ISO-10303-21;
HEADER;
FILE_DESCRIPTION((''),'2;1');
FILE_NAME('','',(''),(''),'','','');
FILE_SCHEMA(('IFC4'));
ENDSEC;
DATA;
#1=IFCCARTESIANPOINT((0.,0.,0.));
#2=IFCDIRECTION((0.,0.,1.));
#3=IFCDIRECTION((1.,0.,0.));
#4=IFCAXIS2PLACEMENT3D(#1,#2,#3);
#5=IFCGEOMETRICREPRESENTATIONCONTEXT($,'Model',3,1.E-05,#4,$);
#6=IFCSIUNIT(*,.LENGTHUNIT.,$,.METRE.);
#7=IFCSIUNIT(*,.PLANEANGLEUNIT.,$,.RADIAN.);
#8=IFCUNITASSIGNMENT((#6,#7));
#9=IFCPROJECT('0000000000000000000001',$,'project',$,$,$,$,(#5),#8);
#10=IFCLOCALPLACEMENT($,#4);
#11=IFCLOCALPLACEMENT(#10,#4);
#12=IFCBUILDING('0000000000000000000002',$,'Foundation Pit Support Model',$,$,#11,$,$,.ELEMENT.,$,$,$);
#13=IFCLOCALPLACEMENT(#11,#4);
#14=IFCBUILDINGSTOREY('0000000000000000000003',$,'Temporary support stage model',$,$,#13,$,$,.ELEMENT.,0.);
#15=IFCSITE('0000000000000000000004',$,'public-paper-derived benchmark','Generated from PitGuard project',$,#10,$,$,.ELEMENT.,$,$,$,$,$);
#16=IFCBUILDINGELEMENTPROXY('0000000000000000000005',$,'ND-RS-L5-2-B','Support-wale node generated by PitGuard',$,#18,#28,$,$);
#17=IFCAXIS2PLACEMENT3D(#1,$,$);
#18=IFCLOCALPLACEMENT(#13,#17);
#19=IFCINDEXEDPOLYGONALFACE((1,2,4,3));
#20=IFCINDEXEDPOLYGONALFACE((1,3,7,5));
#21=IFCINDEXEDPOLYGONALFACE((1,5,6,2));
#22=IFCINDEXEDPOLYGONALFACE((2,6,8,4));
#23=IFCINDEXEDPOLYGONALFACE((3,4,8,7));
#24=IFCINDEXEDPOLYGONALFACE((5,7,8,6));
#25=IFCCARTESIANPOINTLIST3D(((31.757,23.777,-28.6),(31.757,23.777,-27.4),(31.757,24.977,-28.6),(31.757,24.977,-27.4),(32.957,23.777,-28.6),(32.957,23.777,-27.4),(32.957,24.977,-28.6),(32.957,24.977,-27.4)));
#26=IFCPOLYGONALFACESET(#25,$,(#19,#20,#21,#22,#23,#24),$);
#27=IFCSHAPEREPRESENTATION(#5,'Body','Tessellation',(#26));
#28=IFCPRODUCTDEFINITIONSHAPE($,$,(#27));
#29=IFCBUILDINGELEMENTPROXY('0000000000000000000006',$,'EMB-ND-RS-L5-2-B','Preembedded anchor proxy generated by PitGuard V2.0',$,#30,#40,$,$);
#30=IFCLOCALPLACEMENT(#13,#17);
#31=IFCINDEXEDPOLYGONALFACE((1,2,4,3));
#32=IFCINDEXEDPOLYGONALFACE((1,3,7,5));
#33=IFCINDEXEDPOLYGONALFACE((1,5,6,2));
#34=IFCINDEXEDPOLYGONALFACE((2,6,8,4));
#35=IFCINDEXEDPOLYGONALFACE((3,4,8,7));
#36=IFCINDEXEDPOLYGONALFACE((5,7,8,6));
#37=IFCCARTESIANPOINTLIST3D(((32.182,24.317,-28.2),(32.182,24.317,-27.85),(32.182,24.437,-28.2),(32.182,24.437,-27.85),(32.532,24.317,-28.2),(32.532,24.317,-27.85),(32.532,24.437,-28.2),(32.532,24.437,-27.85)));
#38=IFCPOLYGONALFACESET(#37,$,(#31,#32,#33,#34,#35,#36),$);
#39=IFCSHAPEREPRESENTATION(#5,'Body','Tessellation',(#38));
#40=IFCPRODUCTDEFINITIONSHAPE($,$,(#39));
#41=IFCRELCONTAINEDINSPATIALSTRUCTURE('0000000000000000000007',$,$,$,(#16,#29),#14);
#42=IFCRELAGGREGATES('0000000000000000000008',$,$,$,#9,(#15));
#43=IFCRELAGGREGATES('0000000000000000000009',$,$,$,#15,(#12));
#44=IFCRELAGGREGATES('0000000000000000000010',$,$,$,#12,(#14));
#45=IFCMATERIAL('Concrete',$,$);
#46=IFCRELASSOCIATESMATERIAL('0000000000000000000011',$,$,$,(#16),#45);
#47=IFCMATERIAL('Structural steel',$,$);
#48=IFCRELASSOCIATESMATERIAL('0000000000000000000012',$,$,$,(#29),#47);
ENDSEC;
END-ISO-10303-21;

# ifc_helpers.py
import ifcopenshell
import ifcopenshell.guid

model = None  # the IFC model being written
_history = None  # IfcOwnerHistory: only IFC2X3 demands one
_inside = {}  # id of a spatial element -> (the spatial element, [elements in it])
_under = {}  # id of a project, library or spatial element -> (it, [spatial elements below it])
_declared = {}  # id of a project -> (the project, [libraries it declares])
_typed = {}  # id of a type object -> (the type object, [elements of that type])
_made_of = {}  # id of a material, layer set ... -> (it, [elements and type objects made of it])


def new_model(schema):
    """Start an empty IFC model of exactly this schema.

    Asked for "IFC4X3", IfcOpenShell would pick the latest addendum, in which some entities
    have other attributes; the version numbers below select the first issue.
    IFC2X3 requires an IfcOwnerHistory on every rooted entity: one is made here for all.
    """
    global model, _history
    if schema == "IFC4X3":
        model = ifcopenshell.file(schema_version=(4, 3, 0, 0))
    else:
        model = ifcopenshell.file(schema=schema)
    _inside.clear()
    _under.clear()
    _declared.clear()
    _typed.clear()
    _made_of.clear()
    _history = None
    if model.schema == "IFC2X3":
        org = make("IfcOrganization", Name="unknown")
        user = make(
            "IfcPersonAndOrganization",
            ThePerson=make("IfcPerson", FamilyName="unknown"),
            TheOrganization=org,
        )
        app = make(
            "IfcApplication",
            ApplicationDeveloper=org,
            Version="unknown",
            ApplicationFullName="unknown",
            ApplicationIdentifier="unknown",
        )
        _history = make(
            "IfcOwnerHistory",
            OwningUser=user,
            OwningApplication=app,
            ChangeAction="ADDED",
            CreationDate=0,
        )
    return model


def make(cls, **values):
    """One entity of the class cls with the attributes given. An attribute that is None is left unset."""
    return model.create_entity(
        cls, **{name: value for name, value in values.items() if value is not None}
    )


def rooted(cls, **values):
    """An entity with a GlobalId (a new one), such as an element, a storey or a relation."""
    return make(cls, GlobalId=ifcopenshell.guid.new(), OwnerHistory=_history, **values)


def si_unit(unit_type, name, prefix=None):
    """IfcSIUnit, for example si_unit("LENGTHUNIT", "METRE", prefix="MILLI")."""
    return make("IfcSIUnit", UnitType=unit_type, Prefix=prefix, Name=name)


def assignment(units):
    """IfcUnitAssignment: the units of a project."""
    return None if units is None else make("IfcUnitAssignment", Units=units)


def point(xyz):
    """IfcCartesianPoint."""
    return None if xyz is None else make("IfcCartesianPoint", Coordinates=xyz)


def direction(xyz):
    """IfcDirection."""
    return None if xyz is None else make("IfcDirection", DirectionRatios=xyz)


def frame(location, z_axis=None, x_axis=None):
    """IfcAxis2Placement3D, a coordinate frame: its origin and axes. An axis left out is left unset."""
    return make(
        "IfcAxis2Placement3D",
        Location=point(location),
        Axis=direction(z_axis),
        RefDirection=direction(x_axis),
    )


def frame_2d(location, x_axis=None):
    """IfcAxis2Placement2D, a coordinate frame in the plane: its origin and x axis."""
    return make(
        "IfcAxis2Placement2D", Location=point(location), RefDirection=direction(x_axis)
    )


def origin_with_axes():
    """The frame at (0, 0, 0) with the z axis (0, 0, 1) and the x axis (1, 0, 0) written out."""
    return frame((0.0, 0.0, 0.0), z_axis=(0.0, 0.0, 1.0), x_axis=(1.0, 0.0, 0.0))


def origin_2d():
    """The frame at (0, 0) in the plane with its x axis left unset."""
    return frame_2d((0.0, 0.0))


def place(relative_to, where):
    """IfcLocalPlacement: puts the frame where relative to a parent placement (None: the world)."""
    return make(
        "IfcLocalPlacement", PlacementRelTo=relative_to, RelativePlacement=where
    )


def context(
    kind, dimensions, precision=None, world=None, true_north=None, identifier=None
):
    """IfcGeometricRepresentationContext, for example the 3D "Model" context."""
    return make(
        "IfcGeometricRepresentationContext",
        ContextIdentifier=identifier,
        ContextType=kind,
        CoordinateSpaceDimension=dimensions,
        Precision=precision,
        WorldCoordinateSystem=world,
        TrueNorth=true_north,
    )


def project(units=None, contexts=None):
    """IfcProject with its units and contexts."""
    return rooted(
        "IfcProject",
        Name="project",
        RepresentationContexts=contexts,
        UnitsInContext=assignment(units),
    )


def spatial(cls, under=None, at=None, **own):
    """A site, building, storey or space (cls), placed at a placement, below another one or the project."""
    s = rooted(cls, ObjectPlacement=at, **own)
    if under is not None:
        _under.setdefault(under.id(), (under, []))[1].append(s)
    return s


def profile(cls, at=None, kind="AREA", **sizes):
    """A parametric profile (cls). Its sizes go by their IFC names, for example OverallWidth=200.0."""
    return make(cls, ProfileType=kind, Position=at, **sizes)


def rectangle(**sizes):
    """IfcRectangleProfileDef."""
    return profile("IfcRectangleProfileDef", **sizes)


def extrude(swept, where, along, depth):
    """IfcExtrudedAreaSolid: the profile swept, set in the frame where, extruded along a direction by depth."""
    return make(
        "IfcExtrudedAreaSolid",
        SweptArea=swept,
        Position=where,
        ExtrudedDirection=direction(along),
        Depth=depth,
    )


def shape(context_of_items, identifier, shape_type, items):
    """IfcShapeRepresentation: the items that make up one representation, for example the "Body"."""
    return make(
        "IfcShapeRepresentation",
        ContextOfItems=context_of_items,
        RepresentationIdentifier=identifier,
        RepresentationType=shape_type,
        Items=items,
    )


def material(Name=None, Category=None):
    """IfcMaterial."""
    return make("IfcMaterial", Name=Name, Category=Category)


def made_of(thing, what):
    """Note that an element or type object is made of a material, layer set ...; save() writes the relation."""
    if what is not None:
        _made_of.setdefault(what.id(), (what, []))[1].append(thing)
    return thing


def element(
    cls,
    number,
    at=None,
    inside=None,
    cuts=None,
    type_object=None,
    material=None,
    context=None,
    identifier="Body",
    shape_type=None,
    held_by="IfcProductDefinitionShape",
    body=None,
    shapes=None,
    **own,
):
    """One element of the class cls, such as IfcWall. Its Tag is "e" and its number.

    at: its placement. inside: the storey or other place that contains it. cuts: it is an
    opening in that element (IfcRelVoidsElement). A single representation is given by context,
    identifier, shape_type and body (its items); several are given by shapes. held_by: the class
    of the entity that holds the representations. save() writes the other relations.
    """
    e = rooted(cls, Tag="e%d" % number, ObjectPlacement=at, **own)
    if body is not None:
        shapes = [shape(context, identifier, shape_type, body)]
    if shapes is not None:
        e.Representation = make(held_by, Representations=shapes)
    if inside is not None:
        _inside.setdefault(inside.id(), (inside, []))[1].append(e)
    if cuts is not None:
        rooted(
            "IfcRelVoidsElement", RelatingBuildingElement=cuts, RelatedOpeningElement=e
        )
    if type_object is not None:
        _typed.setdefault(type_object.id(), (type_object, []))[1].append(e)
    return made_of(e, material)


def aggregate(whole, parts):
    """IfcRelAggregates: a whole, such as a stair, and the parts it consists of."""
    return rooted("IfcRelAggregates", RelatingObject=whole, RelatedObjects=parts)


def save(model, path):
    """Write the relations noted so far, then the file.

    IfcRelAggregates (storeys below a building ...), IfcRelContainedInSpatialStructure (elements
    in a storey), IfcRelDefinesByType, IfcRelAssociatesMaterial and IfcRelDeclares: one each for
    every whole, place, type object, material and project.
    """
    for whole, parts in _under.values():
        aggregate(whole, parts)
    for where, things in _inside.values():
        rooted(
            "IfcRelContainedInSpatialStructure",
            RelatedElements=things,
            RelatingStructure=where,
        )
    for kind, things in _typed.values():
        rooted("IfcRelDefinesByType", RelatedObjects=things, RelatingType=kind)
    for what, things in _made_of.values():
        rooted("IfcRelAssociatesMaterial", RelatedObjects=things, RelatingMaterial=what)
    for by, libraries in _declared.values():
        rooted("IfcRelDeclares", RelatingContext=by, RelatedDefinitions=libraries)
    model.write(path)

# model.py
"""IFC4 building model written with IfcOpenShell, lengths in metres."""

from ifc_helpers import new_model, si_unit, frame, origin_with_axes, origin_2d, place, context, project, spatial, rectangle, extrude, material, element, save


model = new_model("IFC4")

# Units and contexts
model_context = context("Model", 3, precision=1e-05, world=origin_with_axes())
ifc_project = project(units=[si_unit("LENGTHUNIT", "METRE"), si_unit("PLANEANGLEUNIT", "RADIAN")], contexts=[model_context])

# Site, building, storey
site_placement = place(None, origin_with_axes())
site = spatial("IfcSite", under=ifc_project, at=site_placement, Name="public-paper-derived benchmark", Description="Generated from PitGuard project", CompositionType="ELEMENT")
building_placement = place(site_placement, origin_with_axes())
building = spatial("IfcBuilding", under=site, at=building_placement, Name="Foundation Pit Support Model", CompositionType="ELEMENT")
storey_placement = place(building_placement, origin_with_axes())
storey = spatial("IfcBuildingStorey", under=building, at=storey_placement, Name="Temporary support stage model", CompositionType="ELEMENT", Elevation=0.0)

# Shared definitions
ifc_material_1 = material(Name="Structural steel")

# Shared definitions
ifc_material_2 = material(Name="Concrete")

# Building element proxies
proxy_1_placement = place(storey_placement, frame((32.357, 24.377, -28.6), z_axis=(0.0, 0.0, 1.0), x_axis=(1.0, 0.0, 0.0)))
element("IfcBuildingElementProxy", 1, at=proxy_1_placement, inside=storey, material=ifc_material_2, Name="ND-RS-L5-2-B", Description="Support-wale node generated by PitGuard", context=model_context, shape_type="SweptSolid", body=[
    extrude(rectangle(XDim=1.2, YDim=1.2, at=origin_2d()), origin_with_axes(), (0.0, 0.0, 1.0), 1.2),
])
proxy_2_placement = place(storey_placement, frame((32.357, 24.377, -28.2), z_axis=(0.0, 0.0, 1.0), x_axis=(1.0, 0.0, 0.0)))
element("IfcBuildingElementProxy", 2, at=proxy_2_placement, inside=storey, material=ifc_material_1, Name="EMB-ND-RS-L5-2-B", Description="Preembedded anchor proxy generated by PitGuard V2.0", context=model_context, shape_type="SweptSolid", body=[
    extrude(rectangle(XDim=0.35, YDim=0.12, at=origin_2d()), origin_with_axes(), (0.0, 0.0, 1.0), 0.35),
])

save(model, "model.ifc")
